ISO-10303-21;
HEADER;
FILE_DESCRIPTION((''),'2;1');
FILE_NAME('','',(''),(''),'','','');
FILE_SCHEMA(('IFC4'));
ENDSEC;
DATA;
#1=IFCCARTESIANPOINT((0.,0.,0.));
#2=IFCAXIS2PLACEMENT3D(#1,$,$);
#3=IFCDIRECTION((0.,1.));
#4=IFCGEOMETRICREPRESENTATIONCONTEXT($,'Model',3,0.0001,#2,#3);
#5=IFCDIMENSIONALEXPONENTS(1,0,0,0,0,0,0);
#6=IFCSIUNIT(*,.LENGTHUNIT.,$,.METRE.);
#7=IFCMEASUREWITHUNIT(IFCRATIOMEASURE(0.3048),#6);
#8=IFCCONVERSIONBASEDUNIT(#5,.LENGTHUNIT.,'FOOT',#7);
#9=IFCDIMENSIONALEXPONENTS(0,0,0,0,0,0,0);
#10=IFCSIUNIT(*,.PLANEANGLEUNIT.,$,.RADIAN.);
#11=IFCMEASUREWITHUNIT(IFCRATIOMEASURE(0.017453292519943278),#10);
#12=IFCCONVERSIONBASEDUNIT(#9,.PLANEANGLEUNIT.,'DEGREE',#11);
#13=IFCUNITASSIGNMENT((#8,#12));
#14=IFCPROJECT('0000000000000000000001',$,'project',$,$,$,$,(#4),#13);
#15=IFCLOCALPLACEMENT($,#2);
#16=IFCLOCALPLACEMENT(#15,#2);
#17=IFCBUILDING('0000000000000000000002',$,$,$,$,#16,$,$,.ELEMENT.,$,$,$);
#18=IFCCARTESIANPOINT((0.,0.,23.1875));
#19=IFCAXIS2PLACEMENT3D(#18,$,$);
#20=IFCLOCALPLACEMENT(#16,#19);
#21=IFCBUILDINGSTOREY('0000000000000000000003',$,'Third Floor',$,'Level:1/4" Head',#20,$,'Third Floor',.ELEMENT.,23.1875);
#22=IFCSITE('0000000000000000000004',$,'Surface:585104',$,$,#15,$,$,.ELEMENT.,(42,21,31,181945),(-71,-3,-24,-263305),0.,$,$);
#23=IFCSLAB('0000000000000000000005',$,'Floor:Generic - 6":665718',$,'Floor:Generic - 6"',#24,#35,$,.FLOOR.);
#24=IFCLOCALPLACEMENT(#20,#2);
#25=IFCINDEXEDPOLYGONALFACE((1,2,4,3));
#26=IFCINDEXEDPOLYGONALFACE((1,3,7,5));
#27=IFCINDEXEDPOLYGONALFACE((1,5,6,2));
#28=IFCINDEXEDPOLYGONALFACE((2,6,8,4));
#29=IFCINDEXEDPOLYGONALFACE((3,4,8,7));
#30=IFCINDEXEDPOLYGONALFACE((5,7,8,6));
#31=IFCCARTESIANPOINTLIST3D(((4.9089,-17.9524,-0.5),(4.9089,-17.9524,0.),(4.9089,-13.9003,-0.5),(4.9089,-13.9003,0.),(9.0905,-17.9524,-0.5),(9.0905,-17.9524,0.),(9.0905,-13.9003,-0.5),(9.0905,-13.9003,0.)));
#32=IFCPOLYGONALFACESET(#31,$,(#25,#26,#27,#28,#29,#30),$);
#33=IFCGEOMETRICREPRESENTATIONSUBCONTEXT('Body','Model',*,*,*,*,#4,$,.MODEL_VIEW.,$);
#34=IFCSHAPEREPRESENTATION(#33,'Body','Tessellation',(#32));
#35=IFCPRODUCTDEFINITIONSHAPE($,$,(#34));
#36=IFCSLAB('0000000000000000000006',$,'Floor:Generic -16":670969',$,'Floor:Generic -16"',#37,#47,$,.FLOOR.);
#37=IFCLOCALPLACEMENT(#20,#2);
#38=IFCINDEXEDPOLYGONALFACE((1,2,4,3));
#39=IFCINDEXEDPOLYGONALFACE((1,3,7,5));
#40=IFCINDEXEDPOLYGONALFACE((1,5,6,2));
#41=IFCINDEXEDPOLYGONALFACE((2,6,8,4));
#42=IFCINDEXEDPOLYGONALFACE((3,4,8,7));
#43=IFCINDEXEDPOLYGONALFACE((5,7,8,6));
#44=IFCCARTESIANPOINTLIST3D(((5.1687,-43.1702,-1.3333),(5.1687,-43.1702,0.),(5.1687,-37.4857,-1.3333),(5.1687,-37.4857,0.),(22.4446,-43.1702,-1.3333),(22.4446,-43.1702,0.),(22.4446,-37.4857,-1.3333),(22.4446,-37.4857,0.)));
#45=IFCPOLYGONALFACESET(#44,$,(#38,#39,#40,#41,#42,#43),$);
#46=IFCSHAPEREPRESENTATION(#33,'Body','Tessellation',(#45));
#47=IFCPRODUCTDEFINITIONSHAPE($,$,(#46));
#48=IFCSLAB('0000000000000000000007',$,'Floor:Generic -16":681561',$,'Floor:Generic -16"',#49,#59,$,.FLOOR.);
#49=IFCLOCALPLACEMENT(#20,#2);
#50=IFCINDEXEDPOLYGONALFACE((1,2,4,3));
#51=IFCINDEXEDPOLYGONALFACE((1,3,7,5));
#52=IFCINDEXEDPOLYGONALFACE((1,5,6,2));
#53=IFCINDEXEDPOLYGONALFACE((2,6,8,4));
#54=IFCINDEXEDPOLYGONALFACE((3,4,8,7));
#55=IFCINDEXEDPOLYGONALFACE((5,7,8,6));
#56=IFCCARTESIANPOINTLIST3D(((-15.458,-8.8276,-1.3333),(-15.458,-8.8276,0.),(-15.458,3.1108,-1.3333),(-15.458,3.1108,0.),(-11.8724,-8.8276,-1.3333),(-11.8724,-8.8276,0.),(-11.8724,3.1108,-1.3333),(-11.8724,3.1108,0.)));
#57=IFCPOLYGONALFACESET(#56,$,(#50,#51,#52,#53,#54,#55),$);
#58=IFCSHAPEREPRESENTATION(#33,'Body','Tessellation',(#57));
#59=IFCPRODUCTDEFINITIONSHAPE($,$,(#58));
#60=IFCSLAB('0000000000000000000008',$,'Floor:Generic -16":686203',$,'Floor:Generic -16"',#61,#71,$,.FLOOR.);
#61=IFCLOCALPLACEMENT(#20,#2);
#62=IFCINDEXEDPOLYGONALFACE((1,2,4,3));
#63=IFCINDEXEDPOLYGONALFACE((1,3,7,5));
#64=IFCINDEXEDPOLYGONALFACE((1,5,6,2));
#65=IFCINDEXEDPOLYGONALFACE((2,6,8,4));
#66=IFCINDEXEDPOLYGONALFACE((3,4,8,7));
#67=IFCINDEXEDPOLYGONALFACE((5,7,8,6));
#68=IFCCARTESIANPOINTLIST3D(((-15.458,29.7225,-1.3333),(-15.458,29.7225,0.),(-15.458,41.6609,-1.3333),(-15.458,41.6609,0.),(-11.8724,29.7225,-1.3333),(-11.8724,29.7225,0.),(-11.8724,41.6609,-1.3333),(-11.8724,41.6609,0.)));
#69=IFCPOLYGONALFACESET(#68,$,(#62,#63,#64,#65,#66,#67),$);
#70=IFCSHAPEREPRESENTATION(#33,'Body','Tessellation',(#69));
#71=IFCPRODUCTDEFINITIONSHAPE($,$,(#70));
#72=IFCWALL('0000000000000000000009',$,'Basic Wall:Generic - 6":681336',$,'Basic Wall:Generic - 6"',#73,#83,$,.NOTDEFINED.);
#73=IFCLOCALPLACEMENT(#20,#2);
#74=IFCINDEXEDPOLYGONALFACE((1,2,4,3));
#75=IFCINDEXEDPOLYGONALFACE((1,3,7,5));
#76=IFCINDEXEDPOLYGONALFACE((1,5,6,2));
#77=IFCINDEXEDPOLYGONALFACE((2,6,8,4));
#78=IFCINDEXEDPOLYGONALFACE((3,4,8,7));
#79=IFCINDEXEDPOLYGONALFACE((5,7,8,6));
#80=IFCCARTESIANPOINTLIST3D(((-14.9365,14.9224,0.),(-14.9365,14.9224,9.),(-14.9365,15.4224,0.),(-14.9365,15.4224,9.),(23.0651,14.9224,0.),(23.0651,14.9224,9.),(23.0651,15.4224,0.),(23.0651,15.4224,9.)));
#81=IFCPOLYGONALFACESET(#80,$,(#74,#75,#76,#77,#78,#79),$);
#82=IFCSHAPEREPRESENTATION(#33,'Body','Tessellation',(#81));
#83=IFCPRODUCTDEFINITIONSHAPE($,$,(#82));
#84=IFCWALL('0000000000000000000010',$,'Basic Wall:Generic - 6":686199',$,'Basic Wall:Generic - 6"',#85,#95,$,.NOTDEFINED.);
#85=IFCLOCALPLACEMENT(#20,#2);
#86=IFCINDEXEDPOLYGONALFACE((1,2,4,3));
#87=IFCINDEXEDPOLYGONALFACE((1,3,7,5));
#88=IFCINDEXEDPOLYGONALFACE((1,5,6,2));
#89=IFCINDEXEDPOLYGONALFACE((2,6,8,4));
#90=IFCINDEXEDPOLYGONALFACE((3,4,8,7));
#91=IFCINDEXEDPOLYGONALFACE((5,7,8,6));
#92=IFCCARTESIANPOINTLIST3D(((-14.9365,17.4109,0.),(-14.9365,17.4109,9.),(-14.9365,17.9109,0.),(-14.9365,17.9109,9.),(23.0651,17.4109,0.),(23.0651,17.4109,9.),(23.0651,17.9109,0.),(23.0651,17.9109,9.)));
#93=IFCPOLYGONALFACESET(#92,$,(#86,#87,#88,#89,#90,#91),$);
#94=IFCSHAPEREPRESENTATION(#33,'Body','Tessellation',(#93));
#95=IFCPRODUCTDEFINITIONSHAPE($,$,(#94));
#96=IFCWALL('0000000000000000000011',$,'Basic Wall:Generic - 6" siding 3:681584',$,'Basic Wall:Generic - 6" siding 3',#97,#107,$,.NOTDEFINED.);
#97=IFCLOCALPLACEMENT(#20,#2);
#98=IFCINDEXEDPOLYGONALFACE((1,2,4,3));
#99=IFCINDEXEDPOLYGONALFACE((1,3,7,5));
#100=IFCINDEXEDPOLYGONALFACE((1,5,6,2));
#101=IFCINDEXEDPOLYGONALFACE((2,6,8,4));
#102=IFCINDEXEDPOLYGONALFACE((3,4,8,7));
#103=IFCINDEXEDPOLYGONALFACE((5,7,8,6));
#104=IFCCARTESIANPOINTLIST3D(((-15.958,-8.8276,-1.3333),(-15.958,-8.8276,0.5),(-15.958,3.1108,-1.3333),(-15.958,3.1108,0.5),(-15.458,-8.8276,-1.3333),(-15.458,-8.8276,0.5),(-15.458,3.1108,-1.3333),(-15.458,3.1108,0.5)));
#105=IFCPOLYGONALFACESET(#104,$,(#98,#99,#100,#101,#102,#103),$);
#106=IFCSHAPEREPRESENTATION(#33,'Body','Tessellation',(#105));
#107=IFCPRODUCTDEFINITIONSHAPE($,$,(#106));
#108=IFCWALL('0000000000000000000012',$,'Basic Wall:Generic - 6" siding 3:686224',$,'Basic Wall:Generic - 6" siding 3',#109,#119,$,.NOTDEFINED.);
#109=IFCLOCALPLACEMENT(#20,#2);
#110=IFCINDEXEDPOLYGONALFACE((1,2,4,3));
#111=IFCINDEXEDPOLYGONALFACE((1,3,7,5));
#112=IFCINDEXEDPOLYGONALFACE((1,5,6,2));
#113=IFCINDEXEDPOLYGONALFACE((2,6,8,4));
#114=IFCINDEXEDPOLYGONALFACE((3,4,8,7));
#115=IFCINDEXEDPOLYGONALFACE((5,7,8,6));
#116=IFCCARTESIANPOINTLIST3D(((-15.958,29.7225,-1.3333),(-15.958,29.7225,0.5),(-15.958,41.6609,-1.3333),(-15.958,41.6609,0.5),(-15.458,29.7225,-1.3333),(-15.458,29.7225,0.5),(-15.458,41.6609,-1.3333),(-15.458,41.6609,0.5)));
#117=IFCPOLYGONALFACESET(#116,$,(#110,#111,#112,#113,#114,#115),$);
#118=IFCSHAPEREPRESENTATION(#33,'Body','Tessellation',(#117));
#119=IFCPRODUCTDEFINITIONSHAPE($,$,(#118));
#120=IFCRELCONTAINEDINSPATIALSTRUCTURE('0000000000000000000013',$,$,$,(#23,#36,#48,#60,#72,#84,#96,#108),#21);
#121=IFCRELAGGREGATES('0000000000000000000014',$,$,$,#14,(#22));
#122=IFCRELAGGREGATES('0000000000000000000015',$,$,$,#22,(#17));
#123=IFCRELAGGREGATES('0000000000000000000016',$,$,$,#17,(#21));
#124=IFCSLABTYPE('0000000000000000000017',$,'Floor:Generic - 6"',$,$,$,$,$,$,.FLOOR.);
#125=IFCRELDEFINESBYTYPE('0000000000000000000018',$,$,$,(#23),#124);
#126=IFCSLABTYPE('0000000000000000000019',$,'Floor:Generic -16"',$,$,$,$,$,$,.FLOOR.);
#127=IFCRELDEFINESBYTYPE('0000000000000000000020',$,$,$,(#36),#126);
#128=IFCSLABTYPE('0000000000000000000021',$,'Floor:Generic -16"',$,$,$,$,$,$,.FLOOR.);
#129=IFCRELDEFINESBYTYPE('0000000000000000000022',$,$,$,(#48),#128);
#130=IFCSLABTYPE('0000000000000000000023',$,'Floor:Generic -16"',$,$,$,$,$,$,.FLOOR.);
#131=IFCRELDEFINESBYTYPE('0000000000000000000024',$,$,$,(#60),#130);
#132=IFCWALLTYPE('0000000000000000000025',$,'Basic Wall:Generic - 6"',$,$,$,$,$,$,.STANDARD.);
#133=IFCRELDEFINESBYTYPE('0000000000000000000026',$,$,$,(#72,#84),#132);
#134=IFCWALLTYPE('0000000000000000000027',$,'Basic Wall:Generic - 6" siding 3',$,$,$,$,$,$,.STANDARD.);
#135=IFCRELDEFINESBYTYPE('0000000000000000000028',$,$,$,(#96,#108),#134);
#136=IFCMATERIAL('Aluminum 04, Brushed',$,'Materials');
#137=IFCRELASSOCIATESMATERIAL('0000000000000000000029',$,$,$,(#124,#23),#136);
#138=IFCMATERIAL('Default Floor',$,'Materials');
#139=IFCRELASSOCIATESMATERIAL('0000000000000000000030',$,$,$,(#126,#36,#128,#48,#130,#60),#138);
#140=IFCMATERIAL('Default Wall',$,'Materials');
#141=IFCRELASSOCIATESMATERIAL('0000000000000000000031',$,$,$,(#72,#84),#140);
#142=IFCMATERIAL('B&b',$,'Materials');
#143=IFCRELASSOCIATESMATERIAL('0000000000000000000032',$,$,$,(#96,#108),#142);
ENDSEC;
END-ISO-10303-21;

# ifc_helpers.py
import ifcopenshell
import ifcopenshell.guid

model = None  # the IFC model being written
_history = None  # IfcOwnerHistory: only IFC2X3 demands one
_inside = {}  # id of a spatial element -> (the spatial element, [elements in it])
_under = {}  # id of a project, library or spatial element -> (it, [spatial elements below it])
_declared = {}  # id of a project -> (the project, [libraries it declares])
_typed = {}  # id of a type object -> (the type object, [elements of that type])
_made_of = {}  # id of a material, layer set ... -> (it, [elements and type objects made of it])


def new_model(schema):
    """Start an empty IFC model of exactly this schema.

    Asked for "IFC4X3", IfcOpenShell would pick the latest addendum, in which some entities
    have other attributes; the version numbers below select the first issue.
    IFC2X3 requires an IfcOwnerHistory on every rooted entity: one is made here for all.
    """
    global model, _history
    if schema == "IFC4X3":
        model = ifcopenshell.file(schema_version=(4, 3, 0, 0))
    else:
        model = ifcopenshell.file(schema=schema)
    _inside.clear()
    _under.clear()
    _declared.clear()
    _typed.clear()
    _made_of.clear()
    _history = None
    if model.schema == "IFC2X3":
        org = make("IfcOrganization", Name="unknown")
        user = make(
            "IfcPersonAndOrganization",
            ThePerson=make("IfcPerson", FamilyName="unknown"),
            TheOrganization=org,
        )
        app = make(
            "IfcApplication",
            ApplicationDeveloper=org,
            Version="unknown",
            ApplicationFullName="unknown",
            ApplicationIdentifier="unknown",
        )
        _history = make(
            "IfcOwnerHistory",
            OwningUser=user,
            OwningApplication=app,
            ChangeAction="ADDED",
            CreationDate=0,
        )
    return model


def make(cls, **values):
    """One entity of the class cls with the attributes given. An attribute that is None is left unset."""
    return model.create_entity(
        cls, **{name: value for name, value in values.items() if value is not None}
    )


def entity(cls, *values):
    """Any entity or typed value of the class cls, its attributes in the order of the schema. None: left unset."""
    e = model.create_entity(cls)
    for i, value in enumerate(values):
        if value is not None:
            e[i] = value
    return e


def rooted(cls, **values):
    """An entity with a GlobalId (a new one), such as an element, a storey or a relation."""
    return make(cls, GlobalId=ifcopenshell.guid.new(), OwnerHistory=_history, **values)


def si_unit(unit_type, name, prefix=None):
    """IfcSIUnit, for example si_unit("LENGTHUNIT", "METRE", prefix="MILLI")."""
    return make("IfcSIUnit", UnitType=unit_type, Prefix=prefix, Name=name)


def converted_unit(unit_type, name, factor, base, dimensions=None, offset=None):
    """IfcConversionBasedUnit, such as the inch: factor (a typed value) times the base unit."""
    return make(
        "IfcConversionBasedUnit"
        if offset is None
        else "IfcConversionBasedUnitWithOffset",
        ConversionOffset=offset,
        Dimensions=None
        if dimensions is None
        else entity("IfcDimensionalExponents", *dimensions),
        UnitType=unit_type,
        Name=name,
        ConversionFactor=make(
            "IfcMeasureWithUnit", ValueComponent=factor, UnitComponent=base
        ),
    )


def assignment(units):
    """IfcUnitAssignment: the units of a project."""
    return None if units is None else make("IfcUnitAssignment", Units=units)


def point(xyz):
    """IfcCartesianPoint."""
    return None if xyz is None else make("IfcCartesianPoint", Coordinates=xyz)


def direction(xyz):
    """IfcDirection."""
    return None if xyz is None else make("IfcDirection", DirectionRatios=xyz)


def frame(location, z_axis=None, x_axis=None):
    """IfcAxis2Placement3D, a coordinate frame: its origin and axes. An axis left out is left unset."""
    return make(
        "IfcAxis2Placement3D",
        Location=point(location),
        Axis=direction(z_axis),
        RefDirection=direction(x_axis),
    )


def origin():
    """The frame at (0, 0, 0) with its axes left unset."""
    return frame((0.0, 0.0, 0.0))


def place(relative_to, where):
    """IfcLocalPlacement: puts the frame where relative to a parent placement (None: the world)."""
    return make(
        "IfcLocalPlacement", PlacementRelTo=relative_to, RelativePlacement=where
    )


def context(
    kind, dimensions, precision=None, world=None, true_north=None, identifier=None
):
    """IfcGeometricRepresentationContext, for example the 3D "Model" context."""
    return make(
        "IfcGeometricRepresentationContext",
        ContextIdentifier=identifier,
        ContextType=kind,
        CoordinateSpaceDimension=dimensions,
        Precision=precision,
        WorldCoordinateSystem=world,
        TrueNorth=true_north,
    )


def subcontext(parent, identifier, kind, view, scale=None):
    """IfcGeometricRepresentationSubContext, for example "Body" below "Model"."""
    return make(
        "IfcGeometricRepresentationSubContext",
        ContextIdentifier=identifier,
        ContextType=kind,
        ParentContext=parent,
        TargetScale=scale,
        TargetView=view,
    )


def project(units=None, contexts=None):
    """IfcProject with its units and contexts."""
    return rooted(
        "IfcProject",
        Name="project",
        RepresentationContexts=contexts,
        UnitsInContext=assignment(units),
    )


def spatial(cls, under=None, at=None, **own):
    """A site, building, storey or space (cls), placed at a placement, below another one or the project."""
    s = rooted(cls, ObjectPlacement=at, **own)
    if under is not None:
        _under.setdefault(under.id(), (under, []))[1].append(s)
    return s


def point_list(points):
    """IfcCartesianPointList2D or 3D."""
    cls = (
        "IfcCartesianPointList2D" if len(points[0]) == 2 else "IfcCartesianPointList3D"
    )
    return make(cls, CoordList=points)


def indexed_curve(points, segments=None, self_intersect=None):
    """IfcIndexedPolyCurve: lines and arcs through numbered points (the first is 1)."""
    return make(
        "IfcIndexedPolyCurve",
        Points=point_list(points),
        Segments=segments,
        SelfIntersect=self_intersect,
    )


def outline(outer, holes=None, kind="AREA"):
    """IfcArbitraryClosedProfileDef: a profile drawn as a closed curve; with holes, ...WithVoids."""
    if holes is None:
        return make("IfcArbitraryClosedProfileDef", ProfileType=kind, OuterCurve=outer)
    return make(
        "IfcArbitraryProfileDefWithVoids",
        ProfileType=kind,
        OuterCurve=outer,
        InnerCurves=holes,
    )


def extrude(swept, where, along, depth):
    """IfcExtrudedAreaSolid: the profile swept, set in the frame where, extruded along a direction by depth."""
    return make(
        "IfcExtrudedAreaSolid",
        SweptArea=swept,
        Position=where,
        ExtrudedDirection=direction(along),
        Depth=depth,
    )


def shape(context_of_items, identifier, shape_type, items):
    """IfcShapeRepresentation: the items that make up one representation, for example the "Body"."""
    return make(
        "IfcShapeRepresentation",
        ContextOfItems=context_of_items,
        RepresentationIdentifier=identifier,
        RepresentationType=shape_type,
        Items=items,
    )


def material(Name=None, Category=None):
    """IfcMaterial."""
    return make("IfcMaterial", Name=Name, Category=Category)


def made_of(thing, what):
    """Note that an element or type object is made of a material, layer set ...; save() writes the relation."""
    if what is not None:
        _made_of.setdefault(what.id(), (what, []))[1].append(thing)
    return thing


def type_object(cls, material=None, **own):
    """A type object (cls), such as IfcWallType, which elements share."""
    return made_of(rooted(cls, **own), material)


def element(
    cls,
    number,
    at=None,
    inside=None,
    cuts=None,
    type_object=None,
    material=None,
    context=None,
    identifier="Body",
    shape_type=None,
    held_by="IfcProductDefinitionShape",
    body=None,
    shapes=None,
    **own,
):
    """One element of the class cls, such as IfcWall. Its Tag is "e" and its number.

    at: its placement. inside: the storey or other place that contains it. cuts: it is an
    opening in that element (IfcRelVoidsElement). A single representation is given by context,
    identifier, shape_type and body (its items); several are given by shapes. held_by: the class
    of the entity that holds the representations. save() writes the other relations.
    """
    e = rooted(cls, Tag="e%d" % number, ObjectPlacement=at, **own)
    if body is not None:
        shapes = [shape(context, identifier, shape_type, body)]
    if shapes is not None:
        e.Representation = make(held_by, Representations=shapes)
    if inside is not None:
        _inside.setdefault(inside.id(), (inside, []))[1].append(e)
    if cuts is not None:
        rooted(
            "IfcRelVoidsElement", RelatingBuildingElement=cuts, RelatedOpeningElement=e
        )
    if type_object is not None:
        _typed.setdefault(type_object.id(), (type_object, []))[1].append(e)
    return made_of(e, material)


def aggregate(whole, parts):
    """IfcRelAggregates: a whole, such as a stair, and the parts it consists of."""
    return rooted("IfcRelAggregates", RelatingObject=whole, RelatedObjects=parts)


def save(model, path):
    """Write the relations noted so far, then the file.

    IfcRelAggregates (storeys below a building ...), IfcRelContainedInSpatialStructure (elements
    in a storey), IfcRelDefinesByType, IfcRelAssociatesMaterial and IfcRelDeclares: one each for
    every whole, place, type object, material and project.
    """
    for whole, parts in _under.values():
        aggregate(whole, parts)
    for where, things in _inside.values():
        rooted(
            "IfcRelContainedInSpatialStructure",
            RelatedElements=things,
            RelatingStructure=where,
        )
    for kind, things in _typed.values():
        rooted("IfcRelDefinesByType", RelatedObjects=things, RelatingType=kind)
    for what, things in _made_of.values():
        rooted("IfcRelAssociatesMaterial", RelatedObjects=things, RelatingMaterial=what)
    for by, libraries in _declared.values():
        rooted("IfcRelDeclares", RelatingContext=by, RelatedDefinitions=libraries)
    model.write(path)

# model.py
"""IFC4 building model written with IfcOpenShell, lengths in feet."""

from ifc_helpers import new_model, entity, si_unit, converted_unit, direction, frame, origin, place, context, subcontext, project, spatial, indexed_curve, outline, extrude, material, type_object, element, save


model = new_model("IFC4")

# Units and contexts
model_context = context("Model", 3, precision=0.0001, world=origin(), true_north=direction((0.0, 1.0)))
body_context = subcontext(model_context, "Body", "Model", "MODEL_VIEW")
ifc_project = project(units=[converted_unit("LENGTHUNIT", "FOOT", entity("IfcRatioMeasure", 0.3048), si_unit("LENGTHUNIT", "METRE"), dimensions=[1, 0, 0, 0, 0, 0, 0]), converted_unit("PLANEANGLEUNIT", "DEGREE", entity("IfcRatioMeasure", 0.017453292519943278), si_unit("PLANEANGLEUNIT", "RADIAN"), dimensions=[0, 0, 0, 0, 0, 0, 0])], contexts=[model_context])

# Site, building, storey
site_placement = place(None, origin())
site = spatial("IfcSite", under=ifc_project, at=site_placement, Name="Surface:585104", CompositionType="ELEMENT", RefLatitude=(42, 21, 31, 181945), RefLongitude=(-71, -3, -24, -263305), RefElevation=0.0)
building_placement = place(site_placement, origin())
building = spatial("IfcBuilding", under=site, at=building_placement, CompositionType="ELEMENT")
storey_placement = place(building_placement, frame((0.0, 0.0, 23.1875)))
storey = spatial("IfcBuildingStorey", under=building, at=storey_placement, Name="Third Floor", ObjectType="Level:1/4\" Head", LongName="Third Floor", CompositionType="ELEMENT", Elevation=23.1875)

# Slabs
ifc_material_1 = material(Name="Default Floor", Category="Materials")
ifc_material_2 = material(Name="Aluminum 04, Brushed", Category="Materials")
slab_type_1 = type_object("IfcSlabType", Name="Floor:Generic - 6\"", PredefinedType="FLOOR", material=ifc_material_2)
slab_1_placement = place(storey_placement, origin())
element("IfcSlab", 1, at=slab_1_placement, inside=storey, type_object=slab_type_1, material=ifc_material_2, Name="Floor:Generic - 6\":665718", ObjectType="Floor:Generic - 6\"", PredefinedType="FLOOR", context=body_context, shape_type="SweptSolid", body=[
    extrude(outline(indexed_curve([(-2.026, -2.0908), (2.026, -2.0908), (2.026, 2.0908), (-2.026, 2.0908), (-2.026, -2.0908)], self_intersect=False)), frame((6.9997, -15.9264, 0.0), z_axis=(0.0, 0.0, -1.0), x_axis=(0.0, 1.0, 0.0)), (0.0, 0.0, 1.0), 0.5),
])
slab_type_2 = type_object("IfcSlabType", Name="Floor:Generic -16\"", PredefinedType="FLOOR", material=ifc_material_1)
slab_2_placement = place(storey_placement, origin())
element("IfcSlab", 2, at=slab_2_placement, inside=storey, type_object=slab_type_2, material=ifc_material_1, Name="Floor:Generic -16\":670969", ObjectType="Floor:Generic -16\"", PredefinedType="FLOOR", context=body_context, shape_type="SweptSolid", body=[
    extrude(outline(indexed_curve([(-2.8423, -8.638), (2.8423, -8.638), (2.8423, 8.638), (-2.8423, 8.638), (-2.8423, -8.638)], self_intersect=False)), frame((13.8066, -40.3279, 0.0), z_axis=(0.0, 0.0, -1.0), x_axis=(0.0, 1.0, 0.0)), (0.0, 0.0, 1.0), 1.3333),
])
slab_type_3 = type_object("IfcSlabType", Name="Floor:Generic -16\"", PredefinedType="FLOOR", material=ifc_material_1)
slab_3_placement = place(storey_placement, origin())
element("IfcSlab", 3, at=slab_3_placement, inside=storey, type_object=slab_type_3, material=ifc_material_1, Name="Floor:Generic -16\":681561", ObjectType="Floor:Generic -16\"", PredefinedType="FLOOR", context=body_context, shape_type="SweptSolid", body=[
    extrude(outline(indexed_curve([(-5.9692, -1.7928), (5.9692, -1.7928), (5.9692, 1.7928), (-5.9692, 1.7928), (-5.9692, -1.7928)], self_intersect=False)), frame((-13.6652, -2.8584, 0.0), z_axis=(0.0, 0.0, -1.0), x_axis=(0.0, 1.0, 0.0)), (0.0, 0.0, 1.0), 1.3333),
])
slab_type_4 = type_object("IfcSlabType", Name="Floor:Generic -16\"", PredefinedType="FLOOR", material=ifc_material_1)
slab_4_placement = place(storey_placement, origin())
element("IfcSlab", 4, at=slab_4_placement, inside=storey, type_object=slab_type_4, material=ifc_material_1, Name="Floor:Generic -16\":686203", ObjectType="Floor:Generic -16\"", PredefinedType="FLOOR", context=body_context, shape_type="SweptSolid", body=[
    extrude(outline(indexed_curve([(-5.9692, -1.7928), (5.9692, -1.7928), (5.9692, 1.7928), (-5.9692, 1.7928), (-5.9692, -1.7928)], self_intersect=False)), frame((-13.6652, 35.6917, 0.0), z_axis=(0.0, 0.0, -1.0), x_axis=(0.0, 1.0, 0.0)), (0.0, 0.0, 1.0), 1.3333),
])

# Walls
ifc_material_3 = material(Name="Default Wall", Category="Materials")
wall_type_1 = type_object("IfcWallType", Name="Basic Wall:Generic - 6\"", PredefinedType="STANDARD")
wall_1_placement = place(storey_placement, frame((-14.9365, 15.1724, 0.0)))
element("IfcWall", 5, at=wall_1_placement, inside=storey, type_object=wall_type_1, material=ifc_material_3, Name="Basic Wall:Generic - 6\":681336", ObjectType="Basic Wall:Generic - 6\"", PredefinedType="NOTDEFINED", context=body_context, shape_type="SweptSolid", body=[
    extrude(outline(indexed_curve([(-19.0008, -0.25), (19.0008, -0.25), (19.0008, 0.25), (-19.0008, 0.25), (-19.0008, -0.25)], self_intersect=False)), frame((19.0008, 0.0, 0.0)), (0.0, 0.0, 1.0), 9.0),
])
wall_2_placement = place(storey_placement, frame((-14.9365, 17.6609, 0.0)))
element("IfcWall", 6, at=wall_2_placement, inside=storey, type_object=wall_type_1, material=ifc_material_3, Name="Basic Wall:Generic - 6\":686199", ObjectType="Basic Wall:Generic - 6\"", PredefinedType="NOTDEFINED", context=body_context, shape_type="SweptSolid", body=[
    extrude(outline(indexed_curve([(-19.0008, -0.25), (19.0008, -0.25), (19.0008, 0.25), (-19.0008, 0.25), (-19.0008, -0.25)], self_intersect=False)), frame((19.0008, 0.0, 0.0)), (0.0, 0.0, 1.0), 9.0),
])
ifc_material_4 = material(Name="B&b", Category="Materials")
wall_type_2 = type_object("IfcWallType", Name="Basic Wall:Generic - 6\" siding 3", PredefinedType="STANDARD")
wall_3_placement = place(storey_placement, frame((-15.708, 3.1108, -1.3333), z_axis=(0.0, 0.0, 1.0), x_axis=(0.0, -1.0, 0.0)))
element("IfcWall", 7, at=wall_3_placement, inside=storey, type_object=wall_type_2, material=ifc_material_4, Name="Basic Wall:Generic - 6\" siding 3:681584", ObjectType="Basic Wall:Generic - 6\" siding 3", PredefinedType="NOTDEFINED", context=body_context, shape_type="SweptSolid", body=[
    extrude(outline(indexed_curve([(11.9385, -0.25), (11.9385, 0.25), (0.0, 0.25), (0.0, -0.25), (11.9385, -0.25)], self_intersect=False)), origin(), (0.0, 0.0, 1.0), 1.8333),
])
wall_4_placement = place(storey_placement, frame((-15.708, 29.7225, -1.3333), z_axis=(0.0, 0.0, 1.0), x_axis=(0.0, 1.0, 0.0)))
element("IfcWall", 8, at=wall_4_placement, inside=storey, type_object=wall_type_2, material=ifc_material_4, Name="Basic Wall:Generic - 6\" siding 3:686224", ObjectType="Basic Wall:Generic - 6\" siding 3", PredefinedType="NOTDEFINED", context=body_context, shape_type="SweptSolid", body=[
    extrude(outline(indexed_curve([(11.9385, -0.25), (11.9385, 0.25), (0.0, 0.25), (0.0, -0.25), (11.9385, -0.25)], self_intersect=False)), origin(), (0.0, 0.0, 1.0), 1.8333),
])

save(model, "model.ifc")
